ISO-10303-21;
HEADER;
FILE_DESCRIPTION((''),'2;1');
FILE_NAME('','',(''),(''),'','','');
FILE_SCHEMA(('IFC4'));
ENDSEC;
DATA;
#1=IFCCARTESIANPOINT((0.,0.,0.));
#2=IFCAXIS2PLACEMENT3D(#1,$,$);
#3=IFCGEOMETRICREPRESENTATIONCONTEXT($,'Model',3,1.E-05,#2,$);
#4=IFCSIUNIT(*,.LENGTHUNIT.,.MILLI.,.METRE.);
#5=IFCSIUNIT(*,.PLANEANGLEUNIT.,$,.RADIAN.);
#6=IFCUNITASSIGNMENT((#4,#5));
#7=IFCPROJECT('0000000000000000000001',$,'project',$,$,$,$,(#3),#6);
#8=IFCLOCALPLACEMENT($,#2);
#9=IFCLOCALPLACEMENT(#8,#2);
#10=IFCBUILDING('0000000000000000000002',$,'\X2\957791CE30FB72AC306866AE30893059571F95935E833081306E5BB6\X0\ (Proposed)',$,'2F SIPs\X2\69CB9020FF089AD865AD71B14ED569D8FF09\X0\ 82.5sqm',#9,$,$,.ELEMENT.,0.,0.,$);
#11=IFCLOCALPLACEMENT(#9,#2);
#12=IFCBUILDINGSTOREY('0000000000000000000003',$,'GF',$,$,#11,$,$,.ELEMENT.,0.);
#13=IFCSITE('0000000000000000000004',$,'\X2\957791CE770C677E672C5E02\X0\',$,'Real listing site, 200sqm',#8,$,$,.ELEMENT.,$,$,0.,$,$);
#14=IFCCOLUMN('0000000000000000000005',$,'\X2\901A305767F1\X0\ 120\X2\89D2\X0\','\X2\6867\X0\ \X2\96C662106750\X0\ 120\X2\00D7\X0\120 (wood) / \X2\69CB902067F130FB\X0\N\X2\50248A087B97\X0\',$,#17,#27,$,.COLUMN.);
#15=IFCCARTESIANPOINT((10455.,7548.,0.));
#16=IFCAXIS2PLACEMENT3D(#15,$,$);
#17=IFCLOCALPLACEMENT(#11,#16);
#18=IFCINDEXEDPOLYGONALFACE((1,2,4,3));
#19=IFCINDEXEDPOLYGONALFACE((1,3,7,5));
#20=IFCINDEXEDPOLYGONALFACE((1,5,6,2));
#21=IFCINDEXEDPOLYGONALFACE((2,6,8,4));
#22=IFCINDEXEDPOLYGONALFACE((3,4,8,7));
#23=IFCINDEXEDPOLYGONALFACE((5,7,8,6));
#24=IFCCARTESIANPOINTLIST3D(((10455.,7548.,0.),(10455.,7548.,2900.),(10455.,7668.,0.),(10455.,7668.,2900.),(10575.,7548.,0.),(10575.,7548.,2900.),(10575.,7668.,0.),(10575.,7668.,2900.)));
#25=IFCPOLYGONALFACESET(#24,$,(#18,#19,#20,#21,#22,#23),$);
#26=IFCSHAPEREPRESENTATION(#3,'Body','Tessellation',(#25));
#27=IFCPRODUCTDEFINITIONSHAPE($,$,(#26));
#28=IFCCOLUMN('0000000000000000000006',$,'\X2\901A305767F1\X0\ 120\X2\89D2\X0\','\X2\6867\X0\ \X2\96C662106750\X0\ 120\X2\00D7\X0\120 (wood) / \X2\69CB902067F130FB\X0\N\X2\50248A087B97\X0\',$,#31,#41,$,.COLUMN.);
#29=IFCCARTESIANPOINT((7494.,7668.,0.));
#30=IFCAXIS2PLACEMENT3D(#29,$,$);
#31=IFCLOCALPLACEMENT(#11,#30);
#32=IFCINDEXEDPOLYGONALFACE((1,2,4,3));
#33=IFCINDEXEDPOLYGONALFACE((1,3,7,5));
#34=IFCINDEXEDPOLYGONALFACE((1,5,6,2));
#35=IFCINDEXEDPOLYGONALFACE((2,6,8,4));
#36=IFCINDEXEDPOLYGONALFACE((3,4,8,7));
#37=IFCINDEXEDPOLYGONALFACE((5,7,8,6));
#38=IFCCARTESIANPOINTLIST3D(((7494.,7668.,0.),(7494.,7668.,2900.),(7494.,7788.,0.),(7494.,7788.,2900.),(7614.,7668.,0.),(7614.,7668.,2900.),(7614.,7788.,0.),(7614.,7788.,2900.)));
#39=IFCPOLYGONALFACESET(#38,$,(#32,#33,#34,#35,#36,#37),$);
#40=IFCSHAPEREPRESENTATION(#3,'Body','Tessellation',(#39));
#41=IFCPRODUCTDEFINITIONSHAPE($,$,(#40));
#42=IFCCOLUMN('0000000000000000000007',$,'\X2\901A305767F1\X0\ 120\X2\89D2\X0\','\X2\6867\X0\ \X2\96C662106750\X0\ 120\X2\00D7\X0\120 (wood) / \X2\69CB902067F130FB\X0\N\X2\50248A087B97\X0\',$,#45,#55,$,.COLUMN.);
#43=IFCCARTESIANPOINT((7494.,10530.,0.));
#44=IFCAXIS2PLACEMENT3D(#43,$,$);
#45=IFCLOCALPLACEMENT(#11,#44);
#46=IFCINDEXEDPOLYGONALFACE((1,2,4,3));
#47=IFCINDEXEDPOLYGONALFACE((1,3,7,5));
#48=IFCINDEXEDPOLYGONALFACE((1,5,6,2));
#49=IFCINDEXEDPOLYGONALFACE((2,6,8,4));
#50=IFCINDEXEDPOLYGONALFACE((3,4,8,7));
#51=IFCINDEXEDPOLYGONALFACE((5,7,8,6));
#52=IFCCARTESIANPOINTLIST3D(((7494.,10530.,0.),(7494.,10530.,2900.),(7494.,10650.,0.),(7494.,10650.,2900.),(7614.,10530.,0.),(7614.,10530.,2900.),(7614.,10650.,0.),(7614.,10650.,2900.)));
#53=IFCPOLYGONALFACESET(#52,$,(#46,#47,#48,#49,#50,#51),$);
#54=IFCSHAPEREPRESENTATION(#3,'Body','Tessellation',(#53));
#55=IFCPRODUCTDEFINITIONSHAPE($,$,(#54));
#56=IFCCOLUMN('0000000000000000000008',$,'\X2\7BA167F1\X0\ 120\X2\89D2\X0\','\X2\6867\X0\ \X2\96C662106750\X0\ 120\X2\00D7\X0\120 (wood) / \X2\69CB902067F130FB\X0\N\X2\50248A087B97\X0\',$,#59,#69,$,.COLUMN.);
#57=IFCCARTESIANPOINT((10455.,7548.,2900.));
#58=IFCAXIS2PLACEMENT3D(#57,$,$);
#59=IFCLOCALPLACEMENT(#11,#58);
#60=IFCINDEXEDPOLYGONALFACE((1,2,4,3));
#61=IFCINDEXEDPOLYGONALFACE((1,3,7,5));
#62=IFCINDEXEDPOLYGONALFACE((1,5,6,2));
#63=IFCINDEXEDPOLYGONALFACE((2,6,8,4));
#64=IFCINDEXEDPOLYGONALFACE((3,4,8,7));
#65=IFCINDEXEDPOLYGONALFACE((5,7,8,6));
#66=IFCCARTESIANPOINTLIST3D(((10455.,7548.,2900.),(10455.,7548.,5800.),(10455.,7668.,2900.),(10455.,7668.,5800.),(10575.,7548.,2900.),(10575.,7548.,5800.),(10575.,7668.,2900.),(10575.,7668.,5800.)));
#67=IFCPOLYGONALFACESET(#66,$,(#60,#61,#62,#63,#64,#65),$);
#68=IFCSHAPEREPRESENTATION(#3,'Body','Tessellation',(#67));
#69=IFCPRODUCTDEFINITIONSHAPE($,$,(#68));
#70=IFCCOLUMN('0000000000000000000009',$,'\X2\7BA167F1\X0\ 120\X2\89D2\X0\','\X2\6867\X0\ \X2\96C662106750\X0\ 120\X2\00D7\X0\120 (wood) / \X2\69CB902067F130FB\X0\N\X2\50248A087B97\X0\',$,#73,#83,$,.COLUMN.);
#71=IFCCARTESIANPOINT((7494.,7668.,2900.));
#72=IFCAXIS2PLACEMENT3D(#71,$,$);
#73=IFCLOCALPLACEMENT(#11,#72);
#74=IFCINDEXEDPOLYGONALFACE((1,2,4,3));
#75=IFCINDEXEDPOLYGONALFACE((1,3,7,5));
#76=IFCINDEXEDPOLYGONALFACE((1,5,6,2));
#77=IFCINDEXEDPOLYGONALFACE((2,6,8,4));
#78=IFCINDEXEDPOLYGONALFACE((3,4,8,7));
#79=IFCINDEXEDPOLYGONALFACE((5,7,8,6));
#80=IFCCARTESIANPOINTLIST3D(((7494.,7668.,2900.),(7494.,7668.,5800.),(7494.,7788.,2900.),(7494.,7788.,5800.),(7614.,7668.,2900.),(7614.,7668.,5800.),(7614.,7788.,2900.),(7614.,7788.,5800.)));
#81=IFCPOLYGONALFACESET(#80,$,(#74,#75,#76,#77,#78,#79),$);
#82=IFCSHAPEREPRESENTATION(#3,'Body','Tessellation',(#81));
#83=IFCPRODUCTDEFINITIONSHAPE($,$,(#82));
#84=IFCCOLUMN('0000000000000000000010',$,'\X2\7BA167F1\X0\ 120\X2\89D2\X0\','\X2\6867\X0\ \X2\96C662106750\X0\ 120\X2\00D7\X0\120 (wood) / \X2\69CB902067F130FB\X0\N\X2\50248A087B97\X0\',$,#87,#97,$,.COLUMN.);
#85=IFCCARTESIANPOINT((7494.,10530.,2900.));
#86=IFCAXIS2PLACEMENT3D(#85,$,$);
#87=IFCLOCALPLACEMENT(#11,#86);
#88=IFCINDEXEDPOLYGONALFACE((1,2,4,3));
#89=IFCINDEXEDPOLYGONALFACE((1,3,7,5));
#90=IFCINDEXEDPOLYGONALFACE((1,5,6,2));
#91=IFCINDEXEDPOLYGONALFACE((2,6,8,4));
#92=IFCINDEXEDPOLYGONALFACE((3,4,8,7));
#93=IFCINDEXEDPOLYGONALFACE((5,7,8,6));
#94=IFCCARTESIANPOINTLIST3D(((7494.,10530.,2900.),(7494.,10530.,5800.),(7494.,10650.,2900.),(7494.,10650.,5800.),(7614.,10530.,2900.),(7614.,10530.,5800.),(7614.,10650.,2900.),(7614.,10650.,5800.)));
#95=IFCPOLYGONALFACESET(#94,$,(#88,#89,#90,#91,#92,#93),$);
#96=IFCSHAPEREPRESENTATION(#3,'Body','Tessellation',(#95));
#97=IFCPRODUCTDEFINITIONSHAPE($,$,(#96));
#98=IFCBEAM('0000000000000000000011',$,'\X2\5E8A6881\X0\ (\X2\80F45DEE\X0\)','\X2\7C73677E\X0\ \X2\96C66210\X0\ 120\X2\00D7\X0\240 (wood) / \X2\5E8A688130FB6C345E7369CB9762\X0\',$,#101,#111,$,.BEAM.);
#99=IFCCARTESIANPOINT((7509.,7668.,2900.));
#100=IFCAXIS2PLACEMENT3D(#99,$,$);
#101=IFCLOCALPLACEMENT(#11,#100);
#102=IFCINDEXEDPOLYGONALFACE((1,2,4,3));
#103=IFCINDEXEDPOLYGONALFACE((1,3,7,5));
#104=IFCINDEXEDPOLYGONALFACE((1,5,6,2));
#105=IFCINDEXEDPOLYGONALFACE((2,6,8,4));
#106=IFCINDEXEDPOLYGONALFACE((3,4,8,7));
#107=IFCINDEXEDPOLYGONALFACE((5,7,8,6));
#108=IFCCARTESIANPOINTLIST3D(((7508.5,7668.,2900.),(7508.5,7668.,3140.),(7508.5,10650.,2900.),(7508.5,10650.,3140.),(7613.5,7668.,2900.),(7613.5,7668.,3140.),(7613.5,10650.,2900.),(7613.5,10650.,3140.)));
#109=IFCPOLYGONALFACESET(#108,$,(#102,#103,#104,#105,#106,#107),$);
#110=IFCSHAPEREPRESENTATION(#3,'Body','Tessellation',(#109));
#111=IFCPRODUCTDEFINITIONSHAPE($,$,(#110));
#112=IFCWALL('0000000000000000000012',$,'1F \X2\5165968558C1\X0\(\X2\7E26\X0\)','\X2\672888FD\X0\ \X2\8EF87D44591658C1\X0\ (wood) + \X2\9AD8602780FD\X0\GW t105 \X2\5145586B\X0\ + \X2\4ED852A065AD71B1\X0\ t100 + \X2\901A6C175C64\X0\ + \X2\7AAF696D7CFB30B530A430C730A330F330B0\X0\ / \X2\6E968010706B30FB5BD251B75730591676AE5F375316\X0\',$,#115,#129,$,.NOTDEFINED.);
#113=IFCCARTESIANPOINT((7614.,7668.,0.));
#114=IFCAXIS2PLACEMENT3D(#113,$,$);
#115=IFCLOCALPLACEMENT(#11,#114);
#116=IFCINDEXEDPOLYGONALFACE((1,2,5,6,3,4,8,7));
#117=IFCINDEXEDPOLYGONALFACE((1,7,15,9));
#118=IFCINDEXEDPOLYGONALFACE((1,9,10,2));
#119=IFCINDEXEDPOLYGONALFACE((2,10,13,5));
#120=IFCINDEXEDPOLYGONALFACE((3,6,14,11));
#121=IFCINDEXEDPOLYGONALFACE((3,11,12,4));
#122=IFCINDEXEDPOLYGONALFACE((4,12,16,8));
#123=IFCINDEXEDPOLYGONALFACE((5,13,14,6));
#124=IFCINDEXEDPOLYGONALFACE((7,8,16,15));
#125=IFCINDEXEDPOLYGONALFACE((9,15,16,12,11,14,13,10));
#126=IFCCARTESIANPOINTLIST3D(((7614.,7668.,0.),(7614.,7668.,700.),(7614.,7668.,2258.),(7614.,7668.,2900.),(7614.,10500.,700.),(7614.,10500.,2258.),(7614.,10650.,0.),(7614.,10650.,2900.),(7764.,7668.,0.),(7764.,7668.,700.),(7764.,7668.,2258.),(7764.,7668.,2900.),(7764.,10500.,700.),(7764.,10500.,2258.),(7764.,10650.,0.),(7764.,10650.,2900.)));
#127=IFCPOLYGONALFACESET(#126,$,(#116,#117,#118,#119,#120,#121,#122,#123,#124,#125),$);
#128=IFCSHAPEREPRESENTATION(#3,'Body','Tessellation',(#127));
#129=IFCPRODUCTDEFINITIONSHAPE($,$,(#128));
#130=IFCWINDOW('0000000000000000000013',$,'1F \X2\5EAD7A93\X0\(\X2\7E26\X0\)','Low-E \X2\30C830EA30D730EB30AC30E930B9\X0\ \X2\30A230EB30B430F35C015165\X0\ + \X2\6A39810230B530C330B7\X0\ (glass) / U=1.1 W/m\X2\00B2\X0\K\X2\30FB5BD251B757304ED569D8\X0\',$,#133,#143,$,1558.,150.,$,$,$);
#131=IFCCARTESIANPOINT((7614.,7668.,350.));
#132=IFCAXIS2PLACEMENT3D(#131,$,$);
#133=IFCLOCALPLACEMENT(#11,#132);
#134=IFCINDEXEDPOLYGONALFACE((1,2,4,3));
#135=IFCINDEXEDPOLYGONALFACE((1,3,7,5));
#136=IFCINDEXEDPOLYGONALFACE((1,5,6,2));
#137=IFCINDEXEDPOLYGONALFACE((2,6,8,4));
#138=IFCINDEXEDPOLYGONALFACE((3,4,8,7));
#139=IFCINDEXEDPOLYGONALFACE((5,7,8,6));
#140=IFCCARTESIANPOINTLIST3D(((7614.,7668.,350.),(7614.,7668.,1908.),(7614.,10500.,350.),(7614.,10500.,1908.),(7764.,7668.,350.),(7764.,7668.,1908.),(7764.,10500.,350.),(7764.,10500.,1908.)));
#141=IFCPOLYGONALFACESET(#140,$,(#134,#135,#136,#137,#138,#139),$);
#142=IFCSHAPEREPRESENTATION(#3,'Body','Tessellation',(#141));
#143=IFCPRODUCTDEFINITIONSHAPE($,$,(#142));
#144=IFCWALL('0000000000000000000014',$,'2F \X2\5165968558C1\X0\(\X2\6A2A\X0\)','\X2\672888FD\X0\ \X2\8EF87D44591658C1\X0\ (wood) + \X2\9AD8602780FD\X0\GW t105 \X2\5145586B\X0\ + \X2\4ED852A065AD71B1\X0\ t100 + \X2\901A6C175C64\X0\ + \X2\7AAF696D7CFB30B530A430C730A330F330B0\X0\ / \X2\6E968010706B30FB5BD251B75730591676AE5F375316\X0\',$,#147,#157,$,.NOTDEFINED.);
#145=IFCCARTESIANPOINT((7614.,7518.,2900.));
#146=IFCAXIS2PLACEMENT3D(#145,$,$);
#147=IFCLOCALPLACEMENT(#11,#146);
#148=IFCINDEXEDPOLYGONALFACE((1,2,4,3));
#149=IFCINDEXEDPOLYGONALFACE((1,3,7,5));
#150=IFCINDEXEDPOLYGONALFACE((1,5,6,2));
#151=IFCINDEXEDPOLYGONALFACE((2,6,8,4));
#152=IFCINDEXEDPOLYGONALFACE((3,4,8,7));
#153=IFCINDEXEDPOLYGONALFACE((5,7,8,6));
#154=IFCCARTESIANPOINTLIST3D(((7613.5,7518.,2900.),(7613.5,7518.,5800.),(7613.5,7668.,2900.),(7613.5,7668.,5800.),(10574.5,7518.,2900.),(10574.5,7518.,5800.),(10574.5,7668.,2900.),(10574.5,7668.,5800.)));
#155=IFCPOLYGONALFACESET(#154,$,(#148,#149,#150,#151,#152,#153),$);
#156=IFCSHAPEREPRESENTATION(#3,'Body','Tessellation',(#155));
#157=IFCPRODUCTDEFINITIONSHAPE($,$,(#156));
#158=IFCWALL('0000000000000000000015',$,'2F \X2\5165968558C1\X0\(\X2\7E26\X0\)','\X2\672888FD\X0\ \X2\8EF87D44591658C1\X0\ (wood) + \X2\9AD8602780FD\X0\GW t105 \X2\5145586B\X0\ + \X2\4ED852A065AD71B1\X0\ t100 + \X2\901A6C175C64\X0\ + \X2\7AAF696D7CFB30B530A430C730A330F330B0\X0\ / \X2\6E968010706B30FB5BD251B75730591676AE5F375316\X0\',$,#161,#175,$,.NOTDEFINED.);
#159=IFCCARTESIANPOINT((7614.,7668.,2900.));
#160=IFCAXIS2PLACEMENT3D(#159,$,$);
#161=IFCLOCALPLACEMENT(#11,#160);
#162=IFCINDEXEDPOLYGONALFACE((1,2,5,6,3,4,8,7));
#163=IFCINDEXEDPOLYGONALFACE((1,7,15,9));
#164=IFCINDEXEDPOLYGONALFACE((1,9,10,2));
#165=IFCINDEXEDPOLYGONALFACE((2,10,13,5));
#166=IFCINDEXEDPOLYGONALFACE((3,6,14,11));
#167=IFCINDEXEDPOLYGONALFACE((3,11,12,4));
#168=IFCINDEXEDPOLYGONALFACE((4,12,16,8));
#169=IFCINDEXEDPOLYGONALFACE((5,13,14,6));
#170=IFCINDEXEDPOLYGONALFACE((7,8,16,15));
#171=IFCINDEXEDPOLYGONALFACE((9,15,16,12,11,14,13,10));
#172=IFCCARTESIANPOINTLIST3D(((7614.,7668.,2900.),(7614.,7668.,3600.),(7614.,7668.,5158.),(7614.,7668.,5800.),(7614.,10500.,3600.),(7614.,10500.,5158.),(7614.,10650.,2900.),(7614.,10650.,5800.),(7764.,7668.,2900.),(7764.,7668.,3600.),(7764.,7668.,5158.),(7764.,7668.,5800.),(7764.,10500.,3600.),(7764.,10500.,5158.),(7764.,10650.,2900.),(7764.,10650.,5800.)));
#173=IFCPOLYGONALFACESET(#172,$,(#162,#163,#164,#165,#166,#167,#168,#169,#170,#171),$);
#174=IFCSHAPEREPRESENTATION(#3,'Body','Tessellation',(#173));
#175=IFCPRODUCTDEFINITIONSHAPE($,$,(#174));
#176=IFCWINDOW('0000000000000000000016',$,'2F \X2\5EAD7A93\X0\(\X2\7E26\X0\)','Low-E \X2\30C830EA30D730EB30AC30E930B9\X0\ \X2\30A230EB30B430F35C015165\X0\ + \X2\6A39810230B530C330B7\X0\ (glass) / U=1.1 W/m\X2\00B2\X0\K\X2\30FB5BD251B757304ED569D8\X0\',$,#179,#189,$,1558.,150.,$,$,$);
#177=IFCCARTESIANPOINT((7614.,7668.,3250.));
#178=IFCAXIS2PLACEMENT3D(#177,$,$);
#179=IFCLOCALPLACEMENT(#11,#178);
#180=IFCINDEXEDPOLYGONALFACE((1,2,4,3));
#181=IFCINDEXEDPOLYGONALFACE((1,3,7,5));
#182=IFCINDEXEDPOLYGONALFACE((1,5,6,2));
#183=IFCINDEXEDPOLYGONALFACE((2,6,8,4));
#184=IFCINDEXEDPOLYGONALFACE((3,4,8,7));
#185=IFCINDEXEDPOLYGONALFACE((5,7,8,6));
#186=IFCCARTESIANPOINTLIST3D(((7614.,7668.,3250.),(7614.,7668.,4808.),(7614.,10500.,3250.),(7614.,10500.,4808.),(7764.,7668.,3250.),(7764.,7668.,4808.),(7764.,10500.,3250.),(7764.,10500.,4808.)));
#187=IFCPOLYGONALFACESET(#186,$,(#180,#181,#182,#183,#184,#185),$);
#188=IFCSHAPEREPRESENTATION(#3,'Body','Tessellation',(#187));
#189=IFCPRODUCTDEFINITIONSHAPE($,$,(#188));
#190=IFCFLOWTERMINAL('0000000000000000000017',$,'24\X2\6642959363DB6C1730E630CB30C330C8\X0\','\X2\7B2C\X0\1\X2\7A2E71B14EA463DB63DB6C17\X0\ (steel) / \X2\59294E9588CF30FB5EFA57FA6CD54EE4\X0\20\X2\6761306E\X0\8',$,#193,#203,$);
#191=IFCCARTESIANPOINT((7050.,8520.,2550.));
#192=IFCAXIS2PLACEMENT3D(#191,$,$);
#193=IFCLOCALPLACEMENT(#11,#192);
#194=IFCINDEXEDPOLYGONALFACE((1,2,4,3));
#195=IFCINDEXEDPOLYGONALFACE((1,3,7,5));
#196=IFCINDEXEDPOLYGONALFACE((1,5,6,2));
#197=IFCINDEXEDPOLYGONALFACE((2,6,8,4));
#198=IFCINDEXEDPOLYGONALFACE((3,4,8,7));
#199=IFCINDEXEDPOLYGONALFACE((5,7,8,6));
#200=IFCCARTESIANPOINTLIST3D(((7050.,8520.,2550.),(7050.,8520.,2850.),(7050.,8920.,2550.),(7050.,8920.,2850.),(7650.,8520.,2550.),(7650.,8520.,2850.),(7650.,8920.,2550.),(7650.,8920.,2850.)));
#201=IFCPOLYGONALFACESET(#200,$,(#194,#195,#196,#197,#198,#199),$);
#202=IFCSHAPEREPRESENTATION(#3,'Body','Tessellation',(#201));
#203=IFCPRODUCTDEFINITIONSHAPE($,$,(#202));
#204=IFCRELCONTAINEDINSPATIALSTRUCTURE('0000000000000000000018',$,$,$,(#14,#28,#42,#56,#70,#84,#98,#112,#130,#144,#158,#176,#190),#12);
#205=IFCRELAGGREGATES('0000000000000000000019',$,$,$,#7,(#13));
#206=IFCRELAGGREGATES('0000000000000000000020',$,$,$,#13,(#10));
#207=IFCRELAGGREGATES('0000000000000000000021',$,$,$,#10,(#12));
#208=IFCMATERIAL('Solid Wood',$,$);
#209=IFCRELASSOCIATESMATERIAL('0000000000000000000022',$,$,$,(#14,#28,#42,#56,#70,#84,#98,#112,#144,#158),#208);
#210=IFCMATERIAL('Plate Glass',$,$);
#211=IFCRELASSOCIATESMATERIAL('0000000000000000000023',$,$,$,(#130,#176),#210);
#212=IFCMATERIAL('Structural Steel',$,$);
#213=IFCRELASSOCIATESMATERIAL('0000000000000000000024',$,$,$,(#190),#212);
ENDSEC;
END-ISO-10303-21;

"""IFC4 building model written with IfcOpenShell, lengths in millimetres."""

from ifc_helpers import new_model, si_unit, frame, frame_2d, origin, place, context, project, spatial, rectangle, extrude, material, element, fill, save


model = new_model("IFC4")

# Units and contexts
model_context = context("Model", 3, precision=1e-05, world=origin())
ifc_project = project(units=[si_unit("LENGTHUNIT", "METRE", prefix="MILLI"), si_unit("PLANEANGLEUNIT", "RADIAN")], contexts=[model_context])

# Site, building, storey
site_placement = place(None, origin())
site = spatial("IfcSite", under=ifc_project, at=site_placement, Name="長野県松本市", ObjectType="Real listing site, 200sqm", CompositionType="ELEMENT", RefElevation=0.0)
building_placement = place(site_placement, origin())
building = spatial("IfcBuilding", under=site, at=building_placement, Name="長野・犬と暮らす土間広めの家 (Proposed)", ObjectType="2F SIPs構造（高断熱仕様） 82.5sqm", CompositionType="ELEMENT", ElevationOfRefHeight=0.0, ElevationOfTerrain=0.0)
storey_placement = place(building_placement, origin())
storey = spatial("IfcBuildingStorey", under=building, at=storey_placement, Name="GF", CompositionType="ELEMENT", Elevation=0.0)

# Columns
ifc_material_1 = material(Name="Solid Wood")
column_1_placement = place(storey_placement, frame((10455.0, 7548.0, 0.0)))
element("IfcColumn", 1, at=column_1_placement, inside=storey, material=ifc_material_1, Name="通し柱 120角", Description="桧 集成材 120×120 (wood) / 構造柱・N値計算", PredefinedType="COLUMN", context=model_context, shape_type="SweptSolid", body=[
    extrude(rectangle(XDim=120.0, YDim=120.0, at=frame_2d((60.0, 60.0))), frame((10455.0, 7548.0, 0.0)), (0.0, 0.0, 1.0), 2900.0),
])
column_2_placement = place(storey_placement, frame((7494.0, 7668.0, 0.0)))
element("IfcColumn", 2, at=column_2_placement, inside=storey, material=ifc_material_1, Name="通し柱 120角", Description="桧 集成材 120×120 (wood) / 構造柱・N値計算", PredefinedType="COLUMN", context=model_context, shape_type="SweptSolid", body=[
    extrude(rectangle(XDim=120.0, YDim=120.0, at=frame_2d((60.0, 60.0))), frame((7494.0, 7668.0, 0.0)), (0.0, 0.0, 1.0), 2900.0),
])
column_3_placement = place(storey_placement, frame((7494.0, 10530.0, 0.0)))
element("IfcColumn", 3, at=column_3_placement, inside=storey, material=ifc_material_1, Name="通し柱 120角", Description="桧 集成材 120×120 (wood) / 構造柱・N値計算", PredefinedType="COLUMN", context=model_context, shape_type="SweptSolid", body=[
    extrude(rectangle(XDim=120.0, YDim=120.0, at=frame_2d((60.0, 60.0))), frame((7494.0, 10530.0, 0.0)), (0.0, 0.0, 1.0), 2900.0),
])
column_4_placement = place(storey_placement, frame((10455.0, 7548.0, 2900.0)))
element("IfcColumn", 4, at=column_4_placement, inside=storey, material=ifc_material_1, Name="管柱 120角", Description="桧 集成材 120×120 (wood) / 構造柱・N値計算", PredefinedType="COLUMN", context=model_context, shape_type="SweptSolid", body=[
    extrude(rectangle(XDim=120.0, YDim=120.0, at=frame_2d((60.0, 60.0))), frame((10455.0, 7548.0, 2900.0)), (0.0, 0.0, 1.0), 2900.0),
])
column_5_placement = place(storey_placement, frame((7494.0, 7668.0, 2900.0)))
element("IfcColumn", 5, at=column_5_placement, inside=storey, material=ifc_material_1, Name="管柱 120角", Description="桧 集成材 120×120 (wood) / 構造柱・N値計算", PredefinedType="COLUMN", context=model_context, shape_type="SweptSolid", body=[
    extrude(rectangle(XDim=120.0, YDim=120.0, at=frame_2d((60.0, 60.0))), frame((7494.0, 7668.0, 2900.0)), (0.0, 0.0, 1.0), 2900.0),
])
column_6_placement = place(storey_placement, frame((7494.0, 10530.0, 2900.0)))
element("IfcColumn", 6, at=column_6_placement, inside=storey, material=ifc_material_1, Name="管柱 120角", Description="桧 集成材 120×120 (wood) / 構造柱・N値計算", PredefinedType="COLUMN", context=model_context, shape_type="SweptSolid", body=[
    extrude(rectangle(XDim=120.0, YDim=120.0, at=frame_2d((60.0, 60.0))), frame((7494.0, 10530.0, 2900.0)), (0.0, 0.0, 1.0), 2900.0),
])

# Beam
beam_1_placement = place(storey_placement, frame((7509.0, 7668.0, 2900.0)))
element("IfcBeam", 7, at=beam_1_placement, inside=storey, material=ifc_material_1, Name="床梁 (胴差)", Description="米松 集成 120×240 (wood) / 床梁・水平構面", PredefinedType="BEAM", context=model_context, shape_type="SweptSolid", body=[
    extrude(rectangle(XDim=105.0, YDim=2982.0, at=frame_2d((52.0, 1491.0))), frame((7509.0, 7668.0, 2900.0)), (0.0, 0.0, 1.0), 240.0),
])

# Wall, opening, window
wall_1_placement = place(storey_placement, frame((7614.0, 7668.0, 0.0)))
wall_1 = element("IfcWall", 8, at=wall_1_placement, inside=storey, material=ifc_material_1, Name="1F 入隅壁(縦)", Description="木製 軸組外壁 (wood) + 高性能GW t105 充填 + 付加断熱 t100 + 通気層 + 窯業系サイディング / 準耐火・寒冷地外皮強化", PredefinedType="NOTDEFINED", context=model_context, shape_type="SweptSolid", body=[
    extrude(rectangle(XDim=150.0, YDim=2982.0, at=frame_2d((75.0, 1491.0))), frame((7614.0, 7668.0, 0.0)), (0.0, 0.0, 1.0), 2900.0),
])
opening_1_placement = place(storey_placement, frame((7614.0, 7668.0, 350.0)))
opening_1 = element("IfcOpeningElement", 9, at=opening_1_placement, cuts=wall_1, PredefinedType="NOTDEFINED", context=model_context, shape_type="SweptSolid", body=[
    extrude(rectangle(XDim=150.0, YDim=2832.0, at=frame_2d((75.0, 1416.0))), frame((7614.0, 7668.0, 350.0)), (0.0, 0.0, 1.0), 1558.0),
])
ifc_material_2 = material(Name="Plate Glass")
window_1_placement = place(storey_placement, frame((7614.0, 7668.0, 350.0)))
window_1 = element("IfcWindow", 10, at=window_1_placement, inside=storey, material=ifc_material_2, Name="1F 庭窓(縦)", Description="Low-E トリプルガラス アルゴン封入 + 樹脂サッシ (glass) / U=1.1 W/m²K・寒冷地仕様", OverallHeight=1558.0, OverallWidth=150.0, context=model_context, shape_type="SweptSolid", body=[
    extrude(rectangle(XDim=150.0, YDim=2832.0, at=frame_2d((75.0, 1416.0))), frame((7614.0, 7668.0, 350.0)), (0.0, 0.0, 1.0), 1558.0),
])
fill(opening_1, window_1)

# Wall
wall_2_placement = place(storey_placement, frame((7614.0, 7518.0, 2900.0)))
element("IfcWall", 11, at=wall_2_placement, inside=storey, material=ifc_material_1, Name="2F 入隅壁(横)", Description="木製 軸組外壁 (wood) + 高性能GW t105 充填 + 付加断熱 t100 + 通気層 + 窯業系サイディング / 準耐火・寒冷地外皮強化", PredefinedType="NOTDEFINED", context=model_context, shape_type="SweptSolid", body=[
    extrude(rectangle(XDim=2961.0, YDim=150.0, at=frame_2d((1480.0, 75.0))), frame((7614.0, 7518.0, 2900.0)), (0.0, 0.0, 1.0), 2900.0),
])

# Wall, opening, window
wall_3_placement = place(storey_placement, frame((7614.0, 7668.0, 2900.0)))
wall_3 = element("IfcWall", 12, at=wall_3_placement, inside=storey, material=ifc_material_1, Name="2F 入隅壁(縦)", Description="木製 軸組外壁 (wood) + 高性能GW t105 充填 + 付加断熱 t100 + 通気層 + 窯業系サイディング / 準耐火・寒冷地外皮強化", PredefinedType="NOTDEFINED", context=model_context, shape_type="SweptSolid", body=[
    extrude(rectangle(XDim=150.0, YDim=2982.0, at=frame_2d((75.0, 1491.0))), frame((7614.0, 7668.0, 2900.0)), (0.0, 0.0, 1.0), 2900.0),
])
opening_2_placement = place(storey_placement, frame((7614.0, 7668.0, 3250.0)))
opening_2 = element("IfcOpeningElement", 13, at=opening_2_placement, cuts=wall_3, PredefinedType="NOTDEFINED", context=model_context, shape_type="SweptSolid", body=[
    extrude(rectangle(XDim=150.0, YDim=2832.0, at=frame_2d((75.0, 1416.0))), frame((7614.0, 7668.0, 3250.0)), (0.0, 0.0, 1.0), 1558.0),
])
window_2_placement = place(storey_placement, frame((7614.0, 7668.0, 3250.0)))
window_2 = element("IfcWindow", 14, at=window_2_placement, inside=storey, material=ifc_material_2, Name="2F 庭窓(縦)", Description="Low-E トリプルガラス アルゴン封入 + 樹脂サッシ (glass) / U=1.1 W/m²K・寒冷地仕様", OverallHeight=1558.0, OverallWidth=150.0, context=model_context, shape_type="SweptSolid", body=[
    extrude(rectangle(XDim=150.0, YDim=2832.0, at=frame_2d((75.0, 1416.0))), frame((7614.0, 7668.0, 3250.0)), (0.0, 0.0, 1.0), 1558.0),
])
fill(opening_2, window_2)

# Flow terminal
ifc_material_3 = material(Name="Structural Steel")
flow_terminal_placement = place(storey_placement, frame((7050.0, 8520.0, 2550.0)))
element("IfcFlowTerminal", 15, at=flow_terminal_placement, inside=storey, material=ifc_material_3, Name="24時間換気ユニット", Description="第1種熱交換換気 (steel) / 天井裏・建基法令20条の8", context=model_context, shape_type="SweptSolid", body=[
    extrude(rectangle(XDim=600.0, YDim=400.0, at=frame_2d((300.0, 200.0))), frame((7050.0, 8520.0, 2550.0)), (0.0, 0.0, 1.0), 300.0),
])

save(model, "model.ifc")
